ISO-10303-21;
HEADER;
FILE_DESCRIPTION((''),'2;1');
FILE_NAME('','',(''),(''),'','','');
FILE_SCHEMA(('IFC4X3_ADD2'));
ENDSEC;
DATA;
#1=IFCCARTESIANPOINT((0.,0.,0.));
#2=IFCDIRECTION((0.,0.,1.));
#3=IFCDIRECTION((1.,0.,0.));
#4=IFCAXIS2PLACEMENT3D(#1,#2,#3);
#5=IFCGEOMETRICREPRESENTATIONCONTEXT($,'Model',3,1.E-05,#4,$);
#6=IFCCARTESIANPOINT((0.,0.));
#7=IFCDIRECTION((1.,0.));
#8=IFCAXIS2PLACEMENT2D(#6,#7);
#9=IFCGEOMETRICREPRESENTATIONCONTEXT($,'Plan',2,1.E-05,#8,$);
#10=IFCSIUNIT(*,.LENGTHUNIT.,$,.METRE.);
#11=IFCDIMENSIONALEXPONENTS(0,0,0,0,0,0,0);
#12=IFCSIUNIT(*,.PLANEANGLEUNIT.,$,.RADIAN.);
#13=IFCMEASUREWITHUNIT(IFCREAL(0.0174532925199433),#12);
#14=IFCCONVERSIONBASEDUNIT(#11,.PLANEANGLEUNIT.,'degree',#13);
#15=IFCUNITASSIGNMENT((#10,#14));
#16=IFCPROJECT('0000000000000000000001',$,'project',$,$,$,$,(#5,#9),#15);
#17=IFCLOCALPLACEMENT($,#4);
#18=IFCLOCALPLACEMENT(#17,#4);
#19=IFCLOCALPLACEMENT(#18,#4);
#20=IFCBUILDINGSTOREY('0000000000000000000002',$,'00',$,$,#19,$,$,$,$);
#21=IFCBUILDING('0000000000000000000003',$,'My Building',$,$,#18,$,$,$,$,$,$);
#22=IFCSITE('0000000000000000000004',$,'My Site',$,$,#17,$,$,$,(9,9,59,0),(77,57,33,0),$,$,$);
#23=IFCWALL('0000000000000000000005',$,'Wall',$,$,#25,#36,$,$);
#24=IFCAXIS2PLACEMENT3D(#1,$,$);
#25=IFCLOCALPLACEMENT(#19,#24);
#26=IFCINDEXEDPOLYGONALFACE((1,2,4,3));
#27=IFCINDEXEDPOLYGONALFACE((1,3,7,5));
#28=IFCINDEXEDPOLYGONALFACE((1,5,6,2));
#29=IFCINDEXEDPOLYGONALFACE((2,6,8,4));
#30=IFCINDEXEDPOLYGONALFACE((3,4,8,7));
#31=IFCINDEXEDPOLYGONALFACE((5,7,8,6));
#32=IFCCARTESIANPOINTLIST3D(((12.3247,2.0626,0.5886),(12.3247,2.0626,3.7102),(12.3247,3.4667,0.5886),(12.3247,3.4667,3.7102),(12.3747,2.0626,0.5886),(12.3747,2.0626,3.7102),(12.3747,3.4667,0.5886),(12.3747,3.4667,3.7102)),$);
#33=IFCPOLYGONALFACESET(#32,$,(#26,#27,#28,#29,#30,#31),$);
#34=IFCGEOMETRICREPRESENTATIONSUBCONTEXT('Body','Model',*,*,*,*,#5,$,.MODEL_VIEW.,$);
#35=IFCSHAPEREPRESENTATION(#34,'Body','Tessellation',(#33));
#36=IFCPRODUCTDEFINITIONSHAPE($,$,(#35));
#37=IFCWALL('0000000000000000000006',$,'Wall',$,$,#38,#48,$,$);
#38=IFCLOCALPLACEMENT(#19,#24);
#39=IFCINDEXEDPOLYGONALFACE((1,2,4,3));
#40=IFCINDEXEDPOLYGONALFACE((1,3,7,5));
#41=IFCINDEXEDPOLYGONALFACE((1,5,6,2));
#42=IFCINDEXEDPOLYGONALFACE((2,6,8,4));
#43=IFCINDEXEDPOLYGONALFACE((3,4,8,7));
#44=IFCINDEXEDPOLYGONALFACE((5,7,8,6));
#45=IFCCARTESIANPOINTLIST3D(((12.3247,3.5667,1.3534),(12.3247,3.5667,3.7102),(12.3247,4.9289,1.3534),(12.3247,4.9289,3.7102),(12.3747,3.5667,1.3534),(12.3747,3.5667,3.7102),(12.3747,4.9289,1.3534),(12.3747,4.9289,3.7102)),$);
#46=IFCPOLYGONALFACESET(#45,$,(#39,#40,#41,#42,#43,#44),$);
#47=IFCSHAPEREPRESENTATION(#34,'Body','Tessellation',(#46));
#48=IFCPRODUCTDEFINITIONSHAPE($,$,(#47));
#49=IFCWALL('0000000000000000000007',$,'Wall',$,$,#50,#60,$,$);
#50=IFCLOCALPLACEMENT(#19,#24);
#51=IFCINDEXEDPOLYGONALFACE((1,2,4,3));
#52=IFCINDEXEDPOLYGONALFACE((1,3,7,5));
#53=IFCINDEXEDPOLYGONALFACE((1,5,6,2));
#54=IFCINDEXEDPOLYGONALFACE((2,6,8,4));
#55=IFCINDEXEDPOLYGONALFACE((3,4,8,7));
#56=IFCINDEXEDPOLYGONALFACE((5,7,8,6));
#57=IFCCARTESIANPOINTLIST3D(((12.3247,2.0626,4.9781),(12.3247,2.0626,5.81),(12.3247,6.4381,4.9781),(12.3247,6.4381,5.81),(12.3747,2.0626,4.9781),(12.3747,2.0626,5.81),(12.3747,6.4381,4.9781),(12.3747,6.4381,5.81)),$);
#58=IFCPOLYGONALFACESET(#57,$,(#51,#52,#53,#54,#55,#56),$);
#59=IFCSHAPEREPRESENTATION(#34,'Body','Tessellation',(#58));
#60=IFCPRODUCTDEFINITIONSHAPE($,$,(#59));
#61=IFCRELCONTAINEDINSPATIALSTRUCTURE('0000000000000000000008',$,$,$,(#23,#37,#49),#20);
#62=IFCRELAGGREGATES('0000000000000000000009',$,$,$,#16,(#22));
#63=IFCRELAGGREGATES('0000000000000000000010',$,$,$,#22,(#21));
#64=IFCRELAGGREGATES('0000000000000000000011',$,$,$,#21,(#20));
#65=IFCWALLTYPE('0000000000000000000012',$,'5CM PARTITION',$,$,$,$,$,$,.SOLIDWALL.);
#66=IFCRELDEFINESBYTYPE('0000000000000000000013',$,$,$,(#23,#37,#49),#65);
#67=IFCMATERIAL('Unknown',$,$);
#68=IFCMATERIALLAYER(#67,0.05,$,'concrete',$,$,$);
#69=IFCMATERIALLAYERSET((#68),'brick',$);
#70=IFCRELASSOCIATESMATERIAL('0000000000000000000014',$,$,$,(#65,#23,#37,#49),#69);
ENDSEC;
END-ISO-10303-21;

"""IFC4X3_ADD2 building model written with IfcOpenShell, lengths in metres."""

from ifc_helpers import new_model, entity, si_unit, converted_unit, frame, origin_with_axes, origin_2d_with_axis, place, context, subcontext, project, spatial, line, indexed_curve, outline, extrude, material, layer, layer_set, layer_usage, type_object, element, save


model = new_model("IFC4X3_ADD2")

# Units and contexts
model_context = context("Model", 3, precision=1e-05, world=origin_with_axes())
plan_context = context("Plan", 2, precision=1e-05, world=origin_2d_with_axis())
body_context = subcontext(model_context, "Body", "Model", "MODEL_VIEW")
ifc_project = project(units=[si_unit("LENGTHUNIT", "METRE"), converted_unit("PLANEANGLEUNIT", "degree", entity("IfcReal", 0.0174532925199433), si_unit("PLANEANGLEUNIT", "RADIAN"), dimensions=[0, 0, 0, 0, 0, 0, 0])], contexts=[model_context, plan_context])

# Site, building, storey
site_placement = place(None, origin_with_axes())
site = spatial("IfcSite", under=ifc_project, at=site_placement, Name="My Site", RefLatitude=(9, 9, 59, 0), RefLongitude=(77, 57, 33, 0))
building_placement = place(site_placement, origin_with_axes())
building = spatial("IfcBuilding", under=site, at=building_placement, Name="My Building")
storey_placement = place(building_placement, origin_with_axes())
storey = spatial("IfcBuildingStorey", under=building, at=storey_placement, Name="00")

# Walls
ifc_material_1 = material(Name="Unknown")
ifc_layer_1 = layer(ifc_material_1, 0.05, Name="concrete")
ifc_layer_set_1 = layer_set([ifc_layer_1], Name="brick")
wall_type_1 = type_object("IfcWallType", Name="5CM PARTITION", PredefinedType="SOLIDWALL", material=ifc_layer_set_1)
ifc_layer_usage_1 = layer_usage(ifc_layer_set_1, "AXIS2", "POSITIVE", 0.0)
wall_1_placement = place(storey_placement, frame((12.3247, 3.4667, 0.5886), z_axis=(0.0, 0.0, 1.0), x_axis=(0.0, -1.0, 0.0)))
element("IfcWall", 1, at=wall_1_placement, inside=storey, type_object=wall_type_1, material=ifc_layer_usage_1, Name="Wall", context=body_context, shape_type="SweptSolid", body=[
    extrude(outline(indexed_curve([(0.0, 0.0), (0.0, 0.05), (1.4041, 0.05), (1.4041, 0.0)], segments=[line(1, 2, 3, 4, 1)])), origin_with_axes(), (0.0, 0.0, 1.0), 3.1216),
])
ifc_layer_usage_2 = layer_usage(ifc_layer_set_1, "AXIS2", "POSITIVE", 0.0)
wall_2_placement = place(storey_placement, frame((12.3247, 4.9289, 1.3534), z_axis=(0.0, 0.0, 1.0), x_axis=(0.0, -1.0, 0.0)))
element("IfcWall", 2, at=wall_2_placement, inside=storey, type_object=wall_type_1, material=ifc_layer_usage_2, Name="Wall", context=body_context, shape_type="SweptSolid", body=[
    extrude(outline(indexed_curve([(0.0, 0.0), (0.0, 0.05), (1.3622, 0.05), (1.3622, 0.0)], segments=[line(1, 2, 3, 4, 1)])), origin_with_axes(), (0.0, 0.0, 1.0), 2.3568),
])
ifc_layer_usage_3 = layer_usage(ifc_layer_set_1, "AXIS2", "POSITIVE", 0.0)
wall_3_placement = place(storey_placement, frame((12.3247, 6.4381, 4.9781), z_axis=(0.0, 0.0, 1.0), x_axis=(0.0, -1.0, 0.0)))
element("IfcWall", 3, at=wall_3_placement, inside=storey, type_object=wall_type_1, material=ifc_layer_usage_3, Name="Wall", context=body_context, shape_type="SweptSolid", body=[
    extrude(outline(indexed_curve([(0.0, 0.0), (0.0, 0.05), (4.3755, 0.05), (4.3755, 0.0)], segments=[line(1, 2, 3, 4, 1)])), origin_with_axes(), (0.0, 0.0, 1.0), 0.8319),
])

save(model, "model.ifc")
